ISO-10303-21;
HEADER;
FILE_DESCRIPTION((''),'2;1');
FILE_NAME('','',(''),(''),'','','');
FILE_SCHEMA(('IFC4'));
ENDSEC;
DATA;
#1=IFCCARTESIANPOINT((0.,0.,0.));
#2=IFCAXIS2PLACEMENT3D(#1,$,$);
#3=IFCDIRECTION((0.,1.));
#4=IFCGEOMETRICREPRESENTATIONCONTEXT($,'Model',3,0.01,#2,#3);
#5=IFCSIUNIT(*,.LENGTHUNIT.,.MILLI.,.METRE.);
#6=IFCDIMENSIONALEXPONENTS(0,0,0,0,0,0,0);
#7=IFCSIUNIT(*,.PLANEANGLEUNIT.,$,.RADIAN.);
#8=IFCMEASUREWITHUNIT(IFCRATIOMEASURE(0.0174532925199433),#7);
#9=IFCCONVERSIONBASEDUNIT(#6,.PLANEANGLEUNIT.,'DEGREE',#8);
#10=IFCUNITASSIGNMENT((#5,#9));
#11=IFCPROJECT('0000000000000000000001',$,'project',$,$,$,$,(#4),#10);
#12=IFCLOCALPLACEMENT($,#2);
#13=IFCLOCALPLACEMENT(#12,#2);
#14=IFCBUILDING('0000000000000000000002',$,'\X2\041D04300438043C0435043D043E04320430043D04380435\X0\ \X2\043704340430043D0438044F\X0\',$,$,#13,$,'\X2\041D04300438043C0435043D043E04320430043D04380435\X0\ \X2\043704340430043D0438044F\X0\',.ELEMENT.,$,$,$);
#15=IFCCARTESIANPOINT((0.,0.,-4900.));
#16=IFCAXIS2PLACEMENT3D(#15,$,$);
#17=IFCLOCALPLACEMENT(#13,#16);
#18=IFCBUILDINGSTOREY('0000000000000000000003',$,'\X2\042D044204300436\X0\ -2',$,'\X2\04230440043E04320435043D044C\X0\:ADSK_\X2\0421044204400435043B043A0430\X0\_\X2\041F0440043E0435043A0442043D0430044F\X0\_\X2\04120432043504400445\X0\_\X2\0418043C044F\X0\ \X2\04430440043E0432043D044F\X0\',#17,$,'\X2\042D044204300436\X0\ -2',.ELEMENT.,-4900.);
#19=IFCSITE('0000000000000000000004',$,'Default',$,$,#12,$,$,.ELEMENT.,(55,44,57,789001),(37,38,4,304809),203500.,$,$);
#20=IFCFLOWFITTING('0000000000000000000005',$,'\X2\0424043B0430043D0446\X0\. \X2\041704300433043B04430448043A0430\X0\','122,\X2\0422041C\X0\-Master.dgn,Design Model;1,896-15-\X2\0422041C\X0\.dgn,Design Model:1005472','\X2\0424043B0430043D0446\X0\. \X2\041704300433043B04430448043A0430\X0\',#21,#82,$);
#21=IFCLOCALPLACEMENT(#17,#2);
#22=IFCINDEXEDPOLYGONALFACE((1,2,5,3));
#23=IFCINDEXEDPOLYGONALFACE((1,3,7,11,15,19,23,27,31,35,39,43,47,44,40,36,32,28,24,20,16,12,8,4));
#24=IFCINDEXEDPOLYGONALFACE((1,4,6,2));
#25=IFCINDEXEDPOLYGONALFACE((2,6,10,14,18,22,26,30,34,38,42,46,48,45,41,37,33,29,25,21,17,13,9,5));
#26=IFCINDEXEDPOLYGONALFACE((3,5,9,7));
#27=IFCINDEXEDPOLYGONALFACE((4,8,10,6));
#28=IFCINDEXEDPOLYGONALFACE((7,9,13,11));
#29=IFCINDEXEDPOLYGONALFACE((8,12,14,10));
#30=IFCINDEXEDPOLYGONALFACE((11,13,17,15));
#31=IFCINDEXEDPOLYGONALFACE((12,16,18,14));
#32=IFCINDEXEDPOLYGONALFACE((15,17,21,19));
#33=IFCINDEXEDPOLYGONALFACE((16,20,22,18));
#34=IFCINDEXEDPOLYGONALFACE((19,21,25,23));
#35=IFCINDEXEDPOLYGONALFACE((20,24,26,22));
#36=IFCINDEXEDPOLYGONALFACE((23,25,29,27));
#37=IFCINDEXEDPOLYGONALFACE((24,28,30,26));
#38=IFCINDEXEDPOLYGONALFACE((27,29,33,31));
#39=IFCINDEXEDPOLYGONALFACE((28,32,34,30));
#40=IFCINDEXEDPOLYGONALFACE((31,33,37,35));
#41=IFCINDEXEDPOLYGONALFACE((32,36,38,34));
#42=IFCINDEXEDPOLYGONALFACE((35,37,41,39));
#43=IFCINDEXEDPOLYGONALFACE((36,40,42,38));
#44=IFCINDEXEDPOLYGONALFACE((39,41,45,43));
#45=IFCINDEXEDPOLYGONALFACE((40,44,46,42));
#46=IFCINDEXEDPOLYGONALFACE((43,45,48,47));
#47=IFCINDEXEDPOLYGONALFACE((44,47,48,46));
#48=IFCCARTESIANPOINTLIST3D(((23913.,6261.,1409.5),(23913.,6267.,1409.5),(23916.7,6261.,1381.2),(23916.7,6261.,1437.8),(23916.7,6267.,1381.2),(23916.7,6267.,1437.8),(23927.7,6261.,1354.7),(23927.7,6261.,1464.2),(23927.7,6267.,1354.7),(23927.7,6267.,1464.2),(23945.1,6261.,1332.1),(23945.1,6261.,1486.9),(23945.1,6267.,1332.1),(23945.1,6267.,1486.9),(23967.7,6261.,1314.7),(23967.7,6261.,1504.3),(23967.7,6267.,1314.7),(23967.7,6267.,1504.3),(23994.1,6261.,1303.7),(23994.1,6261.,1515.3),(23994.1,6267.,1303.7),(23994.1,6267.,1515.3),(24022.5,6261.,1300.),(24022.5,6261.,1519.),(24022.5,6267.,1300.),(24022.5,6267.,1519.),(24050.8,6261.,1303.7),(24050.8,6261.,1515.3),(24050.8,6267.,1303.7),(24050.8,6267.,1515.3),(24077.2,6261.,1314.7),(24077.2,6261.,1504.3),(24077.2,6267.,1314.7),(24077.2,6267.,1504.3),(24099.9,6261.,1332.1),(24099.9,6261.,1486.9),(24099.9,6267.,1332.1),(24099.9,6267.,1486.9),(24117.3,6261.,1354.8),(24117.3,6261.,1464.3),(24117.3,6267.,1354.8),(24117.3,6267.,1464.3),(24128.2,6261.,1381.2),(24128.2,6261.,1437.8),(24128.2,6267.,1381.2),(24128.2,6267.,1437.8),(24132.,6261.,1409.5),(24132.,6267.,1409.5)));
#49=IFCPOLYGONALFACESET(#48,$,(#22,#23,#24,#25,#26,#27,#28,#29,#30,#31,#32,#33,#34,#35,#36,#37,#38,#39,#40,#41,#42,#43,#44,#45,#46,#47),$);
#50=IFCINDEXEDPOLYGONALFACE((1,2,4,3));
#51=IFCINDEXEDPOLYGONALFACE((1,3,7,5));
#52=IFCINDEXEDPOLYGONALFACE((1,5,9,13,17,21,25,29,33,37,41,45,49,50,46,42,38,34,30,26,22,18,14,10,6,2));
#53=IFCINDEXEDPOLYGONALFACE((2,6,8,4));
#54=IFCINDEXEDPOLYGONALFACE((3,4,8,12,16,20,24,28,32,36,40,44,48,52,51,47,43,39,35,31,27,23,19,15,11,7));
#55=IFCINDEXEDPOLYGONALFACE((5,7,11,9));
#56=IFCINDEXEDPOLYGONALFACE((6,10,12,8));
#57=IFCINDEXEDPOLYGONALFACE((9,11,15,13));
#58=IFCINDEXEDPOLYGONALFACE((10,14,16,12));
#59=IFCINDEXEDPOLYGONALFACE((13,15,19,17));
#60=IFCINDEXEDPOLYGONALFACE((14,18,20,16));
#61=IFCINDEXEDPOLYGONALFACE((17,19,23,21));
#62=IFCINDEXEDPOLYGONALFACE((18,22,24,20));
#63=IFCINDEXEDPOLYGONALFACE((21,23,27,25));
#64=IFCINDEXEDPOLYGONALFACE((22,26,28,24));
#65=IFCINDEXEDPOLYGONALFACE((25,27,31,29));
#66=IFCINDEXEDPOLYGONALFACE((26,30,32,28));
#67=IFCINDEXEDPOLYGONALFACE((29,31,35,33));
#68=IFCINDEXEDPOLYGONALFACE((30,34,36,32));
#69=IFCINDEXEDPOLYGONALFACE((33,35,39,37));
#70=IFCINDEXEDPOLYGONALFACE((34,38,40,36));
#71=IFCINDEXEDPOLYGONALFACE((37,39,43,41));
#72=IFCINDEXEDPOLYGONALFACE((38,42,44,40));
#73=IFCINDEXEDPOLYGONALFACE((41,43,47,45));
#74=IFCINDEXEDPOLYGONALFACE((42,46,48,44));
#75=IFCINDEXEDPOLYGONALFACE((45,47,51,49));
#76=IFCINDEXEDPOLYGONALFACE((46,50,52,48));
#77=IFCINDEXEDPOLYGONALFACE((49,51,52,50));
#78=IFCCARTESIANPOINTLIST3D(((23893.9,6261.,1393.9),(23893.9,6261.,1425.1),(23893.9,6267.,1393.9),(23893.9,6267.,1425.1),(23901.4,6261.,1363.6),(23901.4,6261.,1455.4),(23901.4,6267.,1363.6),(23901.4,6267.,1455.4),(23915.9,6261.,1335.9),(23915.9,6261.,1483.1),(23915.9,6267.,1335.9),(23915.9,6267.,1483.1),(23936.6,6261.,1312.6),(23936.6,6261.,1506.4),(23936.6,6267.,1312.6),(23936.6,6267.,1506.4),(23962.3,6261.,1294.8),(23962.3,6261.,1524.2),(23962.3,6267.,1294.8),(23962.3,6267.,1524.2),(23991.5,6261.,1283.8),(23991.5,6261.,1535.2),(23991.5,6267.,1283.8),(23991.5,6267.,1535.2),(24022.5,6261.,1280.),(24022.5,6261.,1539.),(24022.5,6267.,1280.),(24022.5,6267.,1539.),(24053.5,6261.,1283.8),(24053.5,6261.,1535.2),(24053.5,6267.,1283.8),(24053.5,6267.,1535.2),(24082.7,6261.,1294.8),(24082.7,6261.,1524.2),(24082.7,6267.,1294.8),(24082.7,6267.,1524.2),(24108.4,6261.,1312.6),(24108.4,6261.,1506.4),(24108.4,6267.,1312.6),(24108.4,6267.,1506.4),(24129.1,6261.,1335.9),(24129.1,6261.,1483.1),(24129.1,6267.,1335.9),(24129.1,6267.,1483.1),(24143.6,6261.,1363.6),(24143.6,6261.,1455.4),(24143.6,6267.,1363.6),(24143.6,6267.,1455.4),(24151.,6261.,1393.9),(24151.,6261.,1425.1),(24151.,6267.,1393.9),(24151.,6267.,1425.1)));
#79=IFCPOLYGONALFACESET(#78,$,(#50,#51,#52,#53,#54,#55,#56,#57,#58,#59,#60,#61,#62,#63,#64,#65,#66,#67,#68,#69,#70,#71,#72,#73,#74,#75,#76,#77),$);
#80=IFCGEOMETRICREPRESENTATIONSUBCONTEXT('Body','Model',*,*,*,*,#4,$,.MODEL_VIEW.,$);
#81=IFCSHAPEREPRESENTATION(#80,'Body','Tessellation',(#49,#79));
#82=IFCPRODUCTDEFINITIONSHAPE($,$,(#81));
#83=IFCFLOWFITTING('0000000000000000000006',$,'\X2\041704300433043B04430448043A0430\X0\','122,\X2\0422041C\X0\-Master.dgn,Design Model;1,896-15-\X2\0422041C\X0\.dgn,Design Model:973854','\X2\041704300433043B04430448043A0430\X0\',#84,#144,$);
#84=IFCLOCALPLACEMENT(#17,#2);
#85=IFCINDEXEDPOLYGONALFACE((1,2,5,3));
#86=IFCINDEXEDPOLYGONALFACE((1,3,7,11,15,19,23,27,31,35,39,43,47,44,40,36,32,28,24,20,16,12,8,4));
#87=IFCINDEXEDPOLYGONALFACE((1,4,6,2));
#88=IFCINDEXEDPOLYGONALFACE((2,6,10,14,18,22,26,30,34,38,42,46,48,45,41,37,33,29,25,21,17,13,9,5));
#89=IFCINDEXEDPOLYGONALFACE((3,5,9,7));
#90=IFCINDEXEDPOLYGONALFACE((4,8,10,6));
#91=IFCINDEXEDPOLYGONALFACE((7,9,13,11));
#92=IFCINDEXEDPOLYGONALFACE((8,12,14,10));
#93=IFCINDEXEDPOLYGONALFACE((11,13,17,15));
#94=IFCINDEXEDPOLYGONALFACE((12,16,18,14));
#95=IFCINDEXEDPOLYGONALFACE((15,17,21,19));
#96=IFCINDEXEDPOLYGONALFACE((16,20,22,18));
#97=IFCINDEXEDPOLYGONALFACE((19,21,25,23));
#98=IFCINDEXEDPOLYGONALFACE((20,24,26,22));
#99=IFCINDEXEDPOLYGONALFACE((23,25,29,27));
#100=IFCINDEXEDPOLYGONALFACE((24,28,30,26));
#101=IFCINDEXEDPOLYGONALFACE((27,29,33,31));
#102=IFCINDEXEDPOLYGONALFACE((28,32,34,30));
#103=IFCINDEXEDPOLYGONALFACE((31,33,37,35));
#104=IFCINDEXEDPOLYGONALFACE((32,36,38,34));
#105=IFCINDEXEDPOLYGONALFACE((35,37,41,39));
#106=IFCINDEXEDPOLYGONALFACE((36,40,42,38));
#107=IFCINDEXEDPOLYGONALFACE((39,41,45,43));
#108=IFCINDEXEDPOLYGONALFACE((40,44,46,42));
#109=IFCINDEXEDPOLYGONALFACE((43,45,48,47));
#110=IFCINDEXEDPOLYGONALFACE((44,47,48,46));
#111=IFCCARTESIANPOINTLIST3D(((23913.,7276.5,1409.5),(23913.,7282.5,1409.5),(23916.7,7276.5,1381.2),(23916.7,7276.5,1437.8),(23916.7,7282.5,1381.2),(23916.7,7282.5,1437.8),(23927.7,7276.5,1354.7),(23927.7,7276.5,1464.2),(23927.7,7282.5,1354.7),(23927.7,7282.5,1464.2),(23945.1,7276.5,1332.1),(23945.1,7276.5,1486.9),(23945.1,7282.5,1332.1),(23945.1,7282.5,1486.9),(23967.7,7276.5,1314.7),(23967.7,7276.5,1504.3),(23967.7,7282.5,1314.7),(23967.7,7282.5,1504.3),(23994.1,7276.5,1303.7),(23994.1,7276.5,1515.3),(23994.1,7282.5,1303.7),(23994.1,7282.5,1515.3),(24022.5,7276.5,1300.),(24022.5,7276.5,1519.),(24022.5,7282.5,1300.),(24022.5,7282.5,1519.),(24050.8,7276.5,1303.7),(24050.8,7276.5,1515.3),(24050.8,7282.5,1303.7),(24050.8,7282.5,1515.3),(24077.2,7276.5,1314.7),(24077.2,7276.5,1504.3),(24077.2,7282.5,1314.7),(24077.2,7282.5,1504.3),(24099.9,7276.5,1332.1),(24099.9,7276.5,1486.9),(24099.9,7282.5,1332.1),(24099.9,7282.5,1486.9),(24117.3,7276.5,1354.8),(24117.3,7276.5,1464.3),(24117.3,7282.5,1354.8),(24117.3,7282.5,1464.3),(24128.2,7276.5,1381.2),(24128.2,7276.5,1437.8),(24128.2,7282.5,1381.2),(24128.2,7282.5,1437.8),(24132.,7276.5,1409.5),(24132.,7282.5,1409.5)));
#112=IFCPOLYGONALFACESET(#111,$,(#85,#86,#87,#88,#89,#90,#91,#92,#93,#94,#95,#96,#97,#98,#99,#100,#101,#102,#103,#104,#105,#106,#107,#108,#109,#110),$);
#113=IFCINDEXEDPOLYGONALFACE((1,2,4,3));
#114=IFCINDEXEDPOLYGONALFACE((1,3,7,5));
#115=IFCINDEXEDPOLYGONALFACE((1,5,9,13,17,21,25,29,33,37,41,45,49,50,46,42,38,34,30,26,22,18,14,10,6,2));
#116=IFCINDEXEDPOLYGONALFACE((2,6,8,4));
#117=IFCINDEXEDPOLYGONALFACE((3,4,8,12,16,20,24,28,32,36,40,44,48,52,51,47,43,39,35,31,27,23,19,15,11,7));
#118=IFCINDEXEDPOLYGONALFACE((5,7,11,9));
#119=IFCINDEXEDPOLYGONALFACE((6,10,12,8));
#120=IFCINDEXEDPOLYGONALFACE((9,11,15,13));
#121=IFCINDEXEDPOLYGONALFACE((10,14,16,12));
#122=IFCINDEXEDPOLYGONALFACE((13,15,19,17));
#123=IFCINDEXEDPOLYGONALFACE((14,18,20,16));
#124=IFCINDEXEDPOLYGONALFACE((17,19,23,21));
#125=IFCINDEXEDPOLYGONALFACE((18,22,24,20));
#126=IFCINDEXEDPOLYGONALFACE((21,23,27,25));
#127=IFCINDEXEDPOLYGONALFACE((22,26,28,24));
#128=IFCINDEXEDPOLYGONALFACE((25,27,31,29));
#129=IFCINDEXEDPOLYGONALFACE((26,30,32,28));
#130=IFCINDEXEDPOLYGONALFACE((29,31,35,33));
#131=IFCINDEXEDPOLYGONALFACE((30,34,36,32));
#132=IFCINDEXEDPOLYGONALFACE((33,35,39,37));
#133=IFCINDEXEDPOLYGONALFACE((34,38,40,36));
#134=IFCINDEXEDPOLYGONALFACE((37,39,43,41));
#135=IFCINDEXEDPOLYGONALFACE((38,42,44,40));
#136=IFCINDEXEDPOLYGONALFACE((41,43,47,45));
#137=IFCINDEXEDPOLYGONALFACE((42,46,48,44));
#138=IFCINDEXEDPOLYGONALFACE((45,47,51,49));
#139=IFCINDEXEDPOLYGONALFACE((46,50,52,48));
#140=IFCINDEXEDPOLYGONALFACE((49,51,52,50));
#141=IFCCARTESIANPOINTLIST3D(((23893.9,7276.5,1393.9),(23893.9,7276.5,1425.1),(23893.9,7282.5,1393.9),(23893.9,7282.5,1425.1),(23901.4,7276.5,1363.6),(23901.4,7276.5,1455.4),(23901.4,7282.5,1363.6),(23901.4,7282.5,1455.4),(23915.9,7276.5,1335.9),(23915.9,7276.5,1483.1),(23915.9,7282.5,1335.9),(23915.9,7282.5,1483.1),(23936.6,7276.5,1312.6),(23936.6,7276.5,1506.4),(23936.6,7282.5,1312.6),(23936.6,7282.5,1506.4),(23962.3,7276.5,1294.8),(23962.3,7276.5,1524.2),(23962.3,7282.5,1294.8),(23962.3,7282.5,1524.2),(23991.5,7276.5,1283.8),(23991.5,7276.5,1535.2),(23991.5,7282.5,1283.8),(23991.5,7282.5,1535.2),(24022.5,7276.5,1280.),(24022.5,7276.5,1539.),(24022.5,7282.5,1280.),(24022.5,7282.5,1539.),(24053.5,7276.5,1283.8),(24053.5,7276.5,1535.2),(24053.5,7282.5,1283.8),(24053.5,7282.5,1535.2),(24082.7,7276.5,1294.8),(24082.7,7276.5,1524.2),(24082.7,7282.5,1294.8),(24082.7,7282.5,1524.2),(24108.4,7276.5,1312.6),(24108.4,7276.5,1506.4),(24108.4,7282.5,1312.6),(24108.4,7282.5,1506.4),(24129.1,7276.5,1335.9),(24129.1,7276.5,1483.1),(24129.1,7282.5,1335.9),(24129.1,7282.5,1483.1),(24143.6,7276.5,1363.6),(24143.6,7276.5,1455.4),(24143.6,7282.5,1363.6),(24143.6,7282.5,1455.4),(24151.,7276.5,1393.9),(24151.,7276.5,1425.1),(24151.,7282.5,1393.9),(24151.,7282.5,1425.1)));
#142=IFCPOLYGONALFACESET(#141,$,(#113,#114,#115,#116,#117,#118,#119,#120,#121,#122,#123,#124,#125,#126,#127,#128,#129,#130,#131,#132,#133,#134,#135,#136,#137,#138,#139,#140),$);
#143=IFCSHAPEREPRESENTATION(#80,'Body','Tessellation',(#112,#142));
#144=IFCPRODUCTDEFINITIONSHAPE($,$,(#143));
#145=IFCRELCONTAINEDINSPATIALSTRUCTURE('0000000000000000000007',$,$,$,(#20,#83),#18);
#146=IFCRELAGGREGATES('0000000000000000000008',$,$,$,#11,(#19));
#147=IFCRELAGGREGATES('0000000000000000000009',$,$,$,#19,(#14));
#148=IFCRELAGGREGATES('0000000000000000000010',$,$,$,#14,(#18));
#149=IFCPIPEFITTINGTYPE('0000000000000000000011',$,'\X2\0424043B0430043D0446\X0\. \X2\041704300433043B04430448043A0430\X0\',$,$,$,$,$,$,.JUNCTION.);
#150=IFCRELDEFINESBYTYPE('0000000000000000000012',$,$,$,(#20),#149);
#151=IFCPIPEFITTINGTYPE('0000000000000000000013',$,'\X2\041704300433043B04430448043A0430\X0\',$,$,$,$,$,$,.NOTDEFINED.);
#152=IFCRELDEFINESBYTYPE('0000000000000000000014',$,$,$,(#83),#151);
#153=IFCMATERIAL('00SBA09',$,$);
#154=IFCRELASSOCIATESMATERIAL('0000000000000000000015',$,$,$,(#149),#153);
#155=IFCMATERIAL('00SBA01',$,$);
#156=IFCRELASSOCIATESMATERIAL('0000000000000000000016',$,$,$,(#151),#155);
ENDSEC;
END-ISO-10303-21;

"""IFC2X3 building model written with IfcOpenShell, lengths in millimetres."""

from ifc_helpers import new_model, entity, si_unit, converted_unit, direction, frame, origin, place, context, subcontext, project, spatial, polyline, outline, extrude, material, type_object, element, save


model = new_model("IFC2X3")

# Units and contexts
model_context = context("Model", 3, precision=0.01, world=origin(), true_north=direction((0.0, 1.0)))
body_context = subcontext(model_context, "Body", "Model", "MODEL_VIEW")
ifc_project = project(units=[si_unit("LENGTHUNIT", "METRE", prefix="MILLI"), converted_unit("PLANEANGLEUNIT", "DEGREE", entity("IfcRatioMeasure", 0.0174532925199433), si_unit("PLANEANGLEUNIT", "RADIAN"), dimensions=[0, 0, 0, 0, 0, 0, 0])], contexts=[model_context])

# Site, building, storey
site_placement = place(None, origin())
site = spatial("IfcSite", under=ifc_project, at=site_placement, Name="Default", CompositionType="ELEMENT", RefLatitude=(55, 44, 57, 789001), RefLongitude=(37, 38, 4, 304809), RefElevation=203500.0)
building_placement = place(site_placement, origin())
building = spatial("IfcBuilding", under=site, at=building_placement, Name="Наименование здания", LongName="Наименование здания", CompositionType="ELEMENT")
storey_placement = place(building_placement, frame((0.0, 0.0, -4900.0)))
storey = spatial("IfcBuildingStorey", under=building, at=storey_placement, Name="Этаж -2", ObjectType="Уровень:ADSK_Стрелка_Проектная_Вверх_Имя уровня", LongName="Этаж -2", CompositionType="ELEMENT", Elevation=-4900.0)

# Flow fittings
ifc_material_1 = material(Name="00SBA09")
pipe_fitting_type_1 = type_object("IfcPipeFittingType", Name="Фланц. Заглушка", PredefinedType="JUNCTION", material=ifc_material_1)
flow_fitting_1_placement = place(storey_placement, frame((23893.9, 6261.0, 1280.0)))
element("IfcFlowFitting", 1, at=flow_fitting_1_placement, inside=storey, type_object=pipe_fitting_type_1, Name="Фланц. Заглушка", Description="122,ТМ-Master.dgn,Design Model;1,896-15-ТМ.dgn,Design Model:1005472", ObjectType="Фланц. Заглушка", context=body_context, shape_type="SweptSolid", body=[
    extrude(outline(polyline([(-14.3, -108.6), (14.3, -108.6), (41.9, -101.2), (66.7, -86.9), (86.9, -66.7), (101.2, -41.9), (108.6, -14.3), (108.6, 14.3), (101.2, 41.9), (86.9, 66.7), (66.7, 86.9), (41.9, 101.2), (14.3, 108.6), (-14.3, 108.6), (-41.9, 101.2), (-66.7, 86.9), (-86.9, 66.7), (-101.2, 41.9), (-108.6, 14.3), (-108.6, -14.3), (-101.2, -41.9), (-86.9, -66.7), (-66.7, -86.9), (-41.9, -101.2), (-14.3, -108.6)])), frame((128.6, 0.0, 129.5), z_axis=(0.0, 1.0, 0.0), x_axis=(0.991445, 0.0, -0.130526)), (0.0, 0.0, 1.0), 6.0),
    extrude(outline(polyline([(-15.6, -128.6), (15.6, -128.6), (45.9, -121.1), (73.6, -106.6), (96.9, -85.9), (114.7, -60.2), (125.7, -31.0), (129.5, 0.0), (125.7, 31.0), (114.7, 60.2), (96.9, 85.9), (73.6, 106.6), (45.9, 121.1), (15.6, 128.6), (-15.6, 128.6), (-45.9, 121.1), (-73.6, 106.6), (-96.9, 85.9), (-114.7, 60.2), (-125.7, 31.0), (-129.5, 0.0), (-125.7, -31.0), (-114.7, -60.2), (-96.9, -85.9), (-73.6, -106.6), (-45.9, -121.1), (-15.6, -128.6)])), frame((128.6, 0.0, 129.5), z_axis=(0.0, 1.0, 0.0), x_axis=(0.992709, 0.0, -0.120537)), (0.0, 0.0, 1.0), 6.0),
])
ifc_material_2 = material(Name="00SBA01")
pipe_fitting_type_2 = type_object("IfcPipeFittingType", Name="Заглушка", PredefinedType="NOTDEFINED", material=ifc_material_2)
flow_fitting_2_placement = place(storey_placement, frame((23893.9, 7276.5, 1280.0)))
element("IfcFlowFitting", 2, at=flow_fitting_2_placement, inside=storey, type_object=pipe_fitting_type_2, Name="Заглушка", Description="122,ТМ-Master.dgn,Design Model;1,896-15-ТМ.dgn,Design Model:973854", ObjectType="Заглушка", context=body_context, shape_type="SweptSolid", body=[
    extrude(outline(polyline([(-14.3, -108.6), (14.3, -108.6), (41.9, -101.2), (66.7, -86.9), (86.9, -66.7), (101.2, -41.9), (108.6, -14.3), (108.6, 14.3), (101.2, 41.9), (86.9, 66.7), (66.7, 86.9), (41.9, 101.2), (14.3, 108.6), (-14.3, 108.6), (-41.9, 101.2), (-66.7, 86.9), (-86.9, 66.7), (-101.2, 41.9), (-108.6, 14.3), (-108.6, -14.3), (-101.2, -41.9), (-86.9, -66.7), (-66.7, -86.9), (-41.9, -101.2), (-14.3, -108.6)])), frame((128.6, 0.0, 129.5), z_axis=(0.0, 1.0, 0.0), x_axis=(-0.991445, 0.0, 0.130526)), (0.0, 0.0, 1.0), 6.0),
    extrude(outline(polyline([(-15.6, -128.6), (15.6, -128.6), (45.9, -121.1), (73.6, -106.6), (96.9, -85.9), (114.7, -60.2), (125.7, -31.0), (129.5, 0.0), (125.7, 31.0), (114.7, 60.2), (96.9, 85.9), (73.6, 106.6), (45.9, 121.1), (15.6, 128.6), (-15.6, 128.6), (-45.9, 121.1), (-73.6, 106.6), (-96.9, 85.9), (-114.7, 60.2), (-125.7, 31.0), (-129.5, 0.0), (-125.7, -31.0), (-114.7, -60.2), (-96.9, -85.9), (-73.6, -106.6), (-45.9, -121.1), (-15.6, -128.6)])), frame((128.6, 0.0, 129.5), z_axis=(0.0, 1.0, 0.0), x_axis=(-0.992709, 0.0, 0.120537)), (0.0, 0.0, 1.0), 6.0),
])

save(model, "model.ifc")
